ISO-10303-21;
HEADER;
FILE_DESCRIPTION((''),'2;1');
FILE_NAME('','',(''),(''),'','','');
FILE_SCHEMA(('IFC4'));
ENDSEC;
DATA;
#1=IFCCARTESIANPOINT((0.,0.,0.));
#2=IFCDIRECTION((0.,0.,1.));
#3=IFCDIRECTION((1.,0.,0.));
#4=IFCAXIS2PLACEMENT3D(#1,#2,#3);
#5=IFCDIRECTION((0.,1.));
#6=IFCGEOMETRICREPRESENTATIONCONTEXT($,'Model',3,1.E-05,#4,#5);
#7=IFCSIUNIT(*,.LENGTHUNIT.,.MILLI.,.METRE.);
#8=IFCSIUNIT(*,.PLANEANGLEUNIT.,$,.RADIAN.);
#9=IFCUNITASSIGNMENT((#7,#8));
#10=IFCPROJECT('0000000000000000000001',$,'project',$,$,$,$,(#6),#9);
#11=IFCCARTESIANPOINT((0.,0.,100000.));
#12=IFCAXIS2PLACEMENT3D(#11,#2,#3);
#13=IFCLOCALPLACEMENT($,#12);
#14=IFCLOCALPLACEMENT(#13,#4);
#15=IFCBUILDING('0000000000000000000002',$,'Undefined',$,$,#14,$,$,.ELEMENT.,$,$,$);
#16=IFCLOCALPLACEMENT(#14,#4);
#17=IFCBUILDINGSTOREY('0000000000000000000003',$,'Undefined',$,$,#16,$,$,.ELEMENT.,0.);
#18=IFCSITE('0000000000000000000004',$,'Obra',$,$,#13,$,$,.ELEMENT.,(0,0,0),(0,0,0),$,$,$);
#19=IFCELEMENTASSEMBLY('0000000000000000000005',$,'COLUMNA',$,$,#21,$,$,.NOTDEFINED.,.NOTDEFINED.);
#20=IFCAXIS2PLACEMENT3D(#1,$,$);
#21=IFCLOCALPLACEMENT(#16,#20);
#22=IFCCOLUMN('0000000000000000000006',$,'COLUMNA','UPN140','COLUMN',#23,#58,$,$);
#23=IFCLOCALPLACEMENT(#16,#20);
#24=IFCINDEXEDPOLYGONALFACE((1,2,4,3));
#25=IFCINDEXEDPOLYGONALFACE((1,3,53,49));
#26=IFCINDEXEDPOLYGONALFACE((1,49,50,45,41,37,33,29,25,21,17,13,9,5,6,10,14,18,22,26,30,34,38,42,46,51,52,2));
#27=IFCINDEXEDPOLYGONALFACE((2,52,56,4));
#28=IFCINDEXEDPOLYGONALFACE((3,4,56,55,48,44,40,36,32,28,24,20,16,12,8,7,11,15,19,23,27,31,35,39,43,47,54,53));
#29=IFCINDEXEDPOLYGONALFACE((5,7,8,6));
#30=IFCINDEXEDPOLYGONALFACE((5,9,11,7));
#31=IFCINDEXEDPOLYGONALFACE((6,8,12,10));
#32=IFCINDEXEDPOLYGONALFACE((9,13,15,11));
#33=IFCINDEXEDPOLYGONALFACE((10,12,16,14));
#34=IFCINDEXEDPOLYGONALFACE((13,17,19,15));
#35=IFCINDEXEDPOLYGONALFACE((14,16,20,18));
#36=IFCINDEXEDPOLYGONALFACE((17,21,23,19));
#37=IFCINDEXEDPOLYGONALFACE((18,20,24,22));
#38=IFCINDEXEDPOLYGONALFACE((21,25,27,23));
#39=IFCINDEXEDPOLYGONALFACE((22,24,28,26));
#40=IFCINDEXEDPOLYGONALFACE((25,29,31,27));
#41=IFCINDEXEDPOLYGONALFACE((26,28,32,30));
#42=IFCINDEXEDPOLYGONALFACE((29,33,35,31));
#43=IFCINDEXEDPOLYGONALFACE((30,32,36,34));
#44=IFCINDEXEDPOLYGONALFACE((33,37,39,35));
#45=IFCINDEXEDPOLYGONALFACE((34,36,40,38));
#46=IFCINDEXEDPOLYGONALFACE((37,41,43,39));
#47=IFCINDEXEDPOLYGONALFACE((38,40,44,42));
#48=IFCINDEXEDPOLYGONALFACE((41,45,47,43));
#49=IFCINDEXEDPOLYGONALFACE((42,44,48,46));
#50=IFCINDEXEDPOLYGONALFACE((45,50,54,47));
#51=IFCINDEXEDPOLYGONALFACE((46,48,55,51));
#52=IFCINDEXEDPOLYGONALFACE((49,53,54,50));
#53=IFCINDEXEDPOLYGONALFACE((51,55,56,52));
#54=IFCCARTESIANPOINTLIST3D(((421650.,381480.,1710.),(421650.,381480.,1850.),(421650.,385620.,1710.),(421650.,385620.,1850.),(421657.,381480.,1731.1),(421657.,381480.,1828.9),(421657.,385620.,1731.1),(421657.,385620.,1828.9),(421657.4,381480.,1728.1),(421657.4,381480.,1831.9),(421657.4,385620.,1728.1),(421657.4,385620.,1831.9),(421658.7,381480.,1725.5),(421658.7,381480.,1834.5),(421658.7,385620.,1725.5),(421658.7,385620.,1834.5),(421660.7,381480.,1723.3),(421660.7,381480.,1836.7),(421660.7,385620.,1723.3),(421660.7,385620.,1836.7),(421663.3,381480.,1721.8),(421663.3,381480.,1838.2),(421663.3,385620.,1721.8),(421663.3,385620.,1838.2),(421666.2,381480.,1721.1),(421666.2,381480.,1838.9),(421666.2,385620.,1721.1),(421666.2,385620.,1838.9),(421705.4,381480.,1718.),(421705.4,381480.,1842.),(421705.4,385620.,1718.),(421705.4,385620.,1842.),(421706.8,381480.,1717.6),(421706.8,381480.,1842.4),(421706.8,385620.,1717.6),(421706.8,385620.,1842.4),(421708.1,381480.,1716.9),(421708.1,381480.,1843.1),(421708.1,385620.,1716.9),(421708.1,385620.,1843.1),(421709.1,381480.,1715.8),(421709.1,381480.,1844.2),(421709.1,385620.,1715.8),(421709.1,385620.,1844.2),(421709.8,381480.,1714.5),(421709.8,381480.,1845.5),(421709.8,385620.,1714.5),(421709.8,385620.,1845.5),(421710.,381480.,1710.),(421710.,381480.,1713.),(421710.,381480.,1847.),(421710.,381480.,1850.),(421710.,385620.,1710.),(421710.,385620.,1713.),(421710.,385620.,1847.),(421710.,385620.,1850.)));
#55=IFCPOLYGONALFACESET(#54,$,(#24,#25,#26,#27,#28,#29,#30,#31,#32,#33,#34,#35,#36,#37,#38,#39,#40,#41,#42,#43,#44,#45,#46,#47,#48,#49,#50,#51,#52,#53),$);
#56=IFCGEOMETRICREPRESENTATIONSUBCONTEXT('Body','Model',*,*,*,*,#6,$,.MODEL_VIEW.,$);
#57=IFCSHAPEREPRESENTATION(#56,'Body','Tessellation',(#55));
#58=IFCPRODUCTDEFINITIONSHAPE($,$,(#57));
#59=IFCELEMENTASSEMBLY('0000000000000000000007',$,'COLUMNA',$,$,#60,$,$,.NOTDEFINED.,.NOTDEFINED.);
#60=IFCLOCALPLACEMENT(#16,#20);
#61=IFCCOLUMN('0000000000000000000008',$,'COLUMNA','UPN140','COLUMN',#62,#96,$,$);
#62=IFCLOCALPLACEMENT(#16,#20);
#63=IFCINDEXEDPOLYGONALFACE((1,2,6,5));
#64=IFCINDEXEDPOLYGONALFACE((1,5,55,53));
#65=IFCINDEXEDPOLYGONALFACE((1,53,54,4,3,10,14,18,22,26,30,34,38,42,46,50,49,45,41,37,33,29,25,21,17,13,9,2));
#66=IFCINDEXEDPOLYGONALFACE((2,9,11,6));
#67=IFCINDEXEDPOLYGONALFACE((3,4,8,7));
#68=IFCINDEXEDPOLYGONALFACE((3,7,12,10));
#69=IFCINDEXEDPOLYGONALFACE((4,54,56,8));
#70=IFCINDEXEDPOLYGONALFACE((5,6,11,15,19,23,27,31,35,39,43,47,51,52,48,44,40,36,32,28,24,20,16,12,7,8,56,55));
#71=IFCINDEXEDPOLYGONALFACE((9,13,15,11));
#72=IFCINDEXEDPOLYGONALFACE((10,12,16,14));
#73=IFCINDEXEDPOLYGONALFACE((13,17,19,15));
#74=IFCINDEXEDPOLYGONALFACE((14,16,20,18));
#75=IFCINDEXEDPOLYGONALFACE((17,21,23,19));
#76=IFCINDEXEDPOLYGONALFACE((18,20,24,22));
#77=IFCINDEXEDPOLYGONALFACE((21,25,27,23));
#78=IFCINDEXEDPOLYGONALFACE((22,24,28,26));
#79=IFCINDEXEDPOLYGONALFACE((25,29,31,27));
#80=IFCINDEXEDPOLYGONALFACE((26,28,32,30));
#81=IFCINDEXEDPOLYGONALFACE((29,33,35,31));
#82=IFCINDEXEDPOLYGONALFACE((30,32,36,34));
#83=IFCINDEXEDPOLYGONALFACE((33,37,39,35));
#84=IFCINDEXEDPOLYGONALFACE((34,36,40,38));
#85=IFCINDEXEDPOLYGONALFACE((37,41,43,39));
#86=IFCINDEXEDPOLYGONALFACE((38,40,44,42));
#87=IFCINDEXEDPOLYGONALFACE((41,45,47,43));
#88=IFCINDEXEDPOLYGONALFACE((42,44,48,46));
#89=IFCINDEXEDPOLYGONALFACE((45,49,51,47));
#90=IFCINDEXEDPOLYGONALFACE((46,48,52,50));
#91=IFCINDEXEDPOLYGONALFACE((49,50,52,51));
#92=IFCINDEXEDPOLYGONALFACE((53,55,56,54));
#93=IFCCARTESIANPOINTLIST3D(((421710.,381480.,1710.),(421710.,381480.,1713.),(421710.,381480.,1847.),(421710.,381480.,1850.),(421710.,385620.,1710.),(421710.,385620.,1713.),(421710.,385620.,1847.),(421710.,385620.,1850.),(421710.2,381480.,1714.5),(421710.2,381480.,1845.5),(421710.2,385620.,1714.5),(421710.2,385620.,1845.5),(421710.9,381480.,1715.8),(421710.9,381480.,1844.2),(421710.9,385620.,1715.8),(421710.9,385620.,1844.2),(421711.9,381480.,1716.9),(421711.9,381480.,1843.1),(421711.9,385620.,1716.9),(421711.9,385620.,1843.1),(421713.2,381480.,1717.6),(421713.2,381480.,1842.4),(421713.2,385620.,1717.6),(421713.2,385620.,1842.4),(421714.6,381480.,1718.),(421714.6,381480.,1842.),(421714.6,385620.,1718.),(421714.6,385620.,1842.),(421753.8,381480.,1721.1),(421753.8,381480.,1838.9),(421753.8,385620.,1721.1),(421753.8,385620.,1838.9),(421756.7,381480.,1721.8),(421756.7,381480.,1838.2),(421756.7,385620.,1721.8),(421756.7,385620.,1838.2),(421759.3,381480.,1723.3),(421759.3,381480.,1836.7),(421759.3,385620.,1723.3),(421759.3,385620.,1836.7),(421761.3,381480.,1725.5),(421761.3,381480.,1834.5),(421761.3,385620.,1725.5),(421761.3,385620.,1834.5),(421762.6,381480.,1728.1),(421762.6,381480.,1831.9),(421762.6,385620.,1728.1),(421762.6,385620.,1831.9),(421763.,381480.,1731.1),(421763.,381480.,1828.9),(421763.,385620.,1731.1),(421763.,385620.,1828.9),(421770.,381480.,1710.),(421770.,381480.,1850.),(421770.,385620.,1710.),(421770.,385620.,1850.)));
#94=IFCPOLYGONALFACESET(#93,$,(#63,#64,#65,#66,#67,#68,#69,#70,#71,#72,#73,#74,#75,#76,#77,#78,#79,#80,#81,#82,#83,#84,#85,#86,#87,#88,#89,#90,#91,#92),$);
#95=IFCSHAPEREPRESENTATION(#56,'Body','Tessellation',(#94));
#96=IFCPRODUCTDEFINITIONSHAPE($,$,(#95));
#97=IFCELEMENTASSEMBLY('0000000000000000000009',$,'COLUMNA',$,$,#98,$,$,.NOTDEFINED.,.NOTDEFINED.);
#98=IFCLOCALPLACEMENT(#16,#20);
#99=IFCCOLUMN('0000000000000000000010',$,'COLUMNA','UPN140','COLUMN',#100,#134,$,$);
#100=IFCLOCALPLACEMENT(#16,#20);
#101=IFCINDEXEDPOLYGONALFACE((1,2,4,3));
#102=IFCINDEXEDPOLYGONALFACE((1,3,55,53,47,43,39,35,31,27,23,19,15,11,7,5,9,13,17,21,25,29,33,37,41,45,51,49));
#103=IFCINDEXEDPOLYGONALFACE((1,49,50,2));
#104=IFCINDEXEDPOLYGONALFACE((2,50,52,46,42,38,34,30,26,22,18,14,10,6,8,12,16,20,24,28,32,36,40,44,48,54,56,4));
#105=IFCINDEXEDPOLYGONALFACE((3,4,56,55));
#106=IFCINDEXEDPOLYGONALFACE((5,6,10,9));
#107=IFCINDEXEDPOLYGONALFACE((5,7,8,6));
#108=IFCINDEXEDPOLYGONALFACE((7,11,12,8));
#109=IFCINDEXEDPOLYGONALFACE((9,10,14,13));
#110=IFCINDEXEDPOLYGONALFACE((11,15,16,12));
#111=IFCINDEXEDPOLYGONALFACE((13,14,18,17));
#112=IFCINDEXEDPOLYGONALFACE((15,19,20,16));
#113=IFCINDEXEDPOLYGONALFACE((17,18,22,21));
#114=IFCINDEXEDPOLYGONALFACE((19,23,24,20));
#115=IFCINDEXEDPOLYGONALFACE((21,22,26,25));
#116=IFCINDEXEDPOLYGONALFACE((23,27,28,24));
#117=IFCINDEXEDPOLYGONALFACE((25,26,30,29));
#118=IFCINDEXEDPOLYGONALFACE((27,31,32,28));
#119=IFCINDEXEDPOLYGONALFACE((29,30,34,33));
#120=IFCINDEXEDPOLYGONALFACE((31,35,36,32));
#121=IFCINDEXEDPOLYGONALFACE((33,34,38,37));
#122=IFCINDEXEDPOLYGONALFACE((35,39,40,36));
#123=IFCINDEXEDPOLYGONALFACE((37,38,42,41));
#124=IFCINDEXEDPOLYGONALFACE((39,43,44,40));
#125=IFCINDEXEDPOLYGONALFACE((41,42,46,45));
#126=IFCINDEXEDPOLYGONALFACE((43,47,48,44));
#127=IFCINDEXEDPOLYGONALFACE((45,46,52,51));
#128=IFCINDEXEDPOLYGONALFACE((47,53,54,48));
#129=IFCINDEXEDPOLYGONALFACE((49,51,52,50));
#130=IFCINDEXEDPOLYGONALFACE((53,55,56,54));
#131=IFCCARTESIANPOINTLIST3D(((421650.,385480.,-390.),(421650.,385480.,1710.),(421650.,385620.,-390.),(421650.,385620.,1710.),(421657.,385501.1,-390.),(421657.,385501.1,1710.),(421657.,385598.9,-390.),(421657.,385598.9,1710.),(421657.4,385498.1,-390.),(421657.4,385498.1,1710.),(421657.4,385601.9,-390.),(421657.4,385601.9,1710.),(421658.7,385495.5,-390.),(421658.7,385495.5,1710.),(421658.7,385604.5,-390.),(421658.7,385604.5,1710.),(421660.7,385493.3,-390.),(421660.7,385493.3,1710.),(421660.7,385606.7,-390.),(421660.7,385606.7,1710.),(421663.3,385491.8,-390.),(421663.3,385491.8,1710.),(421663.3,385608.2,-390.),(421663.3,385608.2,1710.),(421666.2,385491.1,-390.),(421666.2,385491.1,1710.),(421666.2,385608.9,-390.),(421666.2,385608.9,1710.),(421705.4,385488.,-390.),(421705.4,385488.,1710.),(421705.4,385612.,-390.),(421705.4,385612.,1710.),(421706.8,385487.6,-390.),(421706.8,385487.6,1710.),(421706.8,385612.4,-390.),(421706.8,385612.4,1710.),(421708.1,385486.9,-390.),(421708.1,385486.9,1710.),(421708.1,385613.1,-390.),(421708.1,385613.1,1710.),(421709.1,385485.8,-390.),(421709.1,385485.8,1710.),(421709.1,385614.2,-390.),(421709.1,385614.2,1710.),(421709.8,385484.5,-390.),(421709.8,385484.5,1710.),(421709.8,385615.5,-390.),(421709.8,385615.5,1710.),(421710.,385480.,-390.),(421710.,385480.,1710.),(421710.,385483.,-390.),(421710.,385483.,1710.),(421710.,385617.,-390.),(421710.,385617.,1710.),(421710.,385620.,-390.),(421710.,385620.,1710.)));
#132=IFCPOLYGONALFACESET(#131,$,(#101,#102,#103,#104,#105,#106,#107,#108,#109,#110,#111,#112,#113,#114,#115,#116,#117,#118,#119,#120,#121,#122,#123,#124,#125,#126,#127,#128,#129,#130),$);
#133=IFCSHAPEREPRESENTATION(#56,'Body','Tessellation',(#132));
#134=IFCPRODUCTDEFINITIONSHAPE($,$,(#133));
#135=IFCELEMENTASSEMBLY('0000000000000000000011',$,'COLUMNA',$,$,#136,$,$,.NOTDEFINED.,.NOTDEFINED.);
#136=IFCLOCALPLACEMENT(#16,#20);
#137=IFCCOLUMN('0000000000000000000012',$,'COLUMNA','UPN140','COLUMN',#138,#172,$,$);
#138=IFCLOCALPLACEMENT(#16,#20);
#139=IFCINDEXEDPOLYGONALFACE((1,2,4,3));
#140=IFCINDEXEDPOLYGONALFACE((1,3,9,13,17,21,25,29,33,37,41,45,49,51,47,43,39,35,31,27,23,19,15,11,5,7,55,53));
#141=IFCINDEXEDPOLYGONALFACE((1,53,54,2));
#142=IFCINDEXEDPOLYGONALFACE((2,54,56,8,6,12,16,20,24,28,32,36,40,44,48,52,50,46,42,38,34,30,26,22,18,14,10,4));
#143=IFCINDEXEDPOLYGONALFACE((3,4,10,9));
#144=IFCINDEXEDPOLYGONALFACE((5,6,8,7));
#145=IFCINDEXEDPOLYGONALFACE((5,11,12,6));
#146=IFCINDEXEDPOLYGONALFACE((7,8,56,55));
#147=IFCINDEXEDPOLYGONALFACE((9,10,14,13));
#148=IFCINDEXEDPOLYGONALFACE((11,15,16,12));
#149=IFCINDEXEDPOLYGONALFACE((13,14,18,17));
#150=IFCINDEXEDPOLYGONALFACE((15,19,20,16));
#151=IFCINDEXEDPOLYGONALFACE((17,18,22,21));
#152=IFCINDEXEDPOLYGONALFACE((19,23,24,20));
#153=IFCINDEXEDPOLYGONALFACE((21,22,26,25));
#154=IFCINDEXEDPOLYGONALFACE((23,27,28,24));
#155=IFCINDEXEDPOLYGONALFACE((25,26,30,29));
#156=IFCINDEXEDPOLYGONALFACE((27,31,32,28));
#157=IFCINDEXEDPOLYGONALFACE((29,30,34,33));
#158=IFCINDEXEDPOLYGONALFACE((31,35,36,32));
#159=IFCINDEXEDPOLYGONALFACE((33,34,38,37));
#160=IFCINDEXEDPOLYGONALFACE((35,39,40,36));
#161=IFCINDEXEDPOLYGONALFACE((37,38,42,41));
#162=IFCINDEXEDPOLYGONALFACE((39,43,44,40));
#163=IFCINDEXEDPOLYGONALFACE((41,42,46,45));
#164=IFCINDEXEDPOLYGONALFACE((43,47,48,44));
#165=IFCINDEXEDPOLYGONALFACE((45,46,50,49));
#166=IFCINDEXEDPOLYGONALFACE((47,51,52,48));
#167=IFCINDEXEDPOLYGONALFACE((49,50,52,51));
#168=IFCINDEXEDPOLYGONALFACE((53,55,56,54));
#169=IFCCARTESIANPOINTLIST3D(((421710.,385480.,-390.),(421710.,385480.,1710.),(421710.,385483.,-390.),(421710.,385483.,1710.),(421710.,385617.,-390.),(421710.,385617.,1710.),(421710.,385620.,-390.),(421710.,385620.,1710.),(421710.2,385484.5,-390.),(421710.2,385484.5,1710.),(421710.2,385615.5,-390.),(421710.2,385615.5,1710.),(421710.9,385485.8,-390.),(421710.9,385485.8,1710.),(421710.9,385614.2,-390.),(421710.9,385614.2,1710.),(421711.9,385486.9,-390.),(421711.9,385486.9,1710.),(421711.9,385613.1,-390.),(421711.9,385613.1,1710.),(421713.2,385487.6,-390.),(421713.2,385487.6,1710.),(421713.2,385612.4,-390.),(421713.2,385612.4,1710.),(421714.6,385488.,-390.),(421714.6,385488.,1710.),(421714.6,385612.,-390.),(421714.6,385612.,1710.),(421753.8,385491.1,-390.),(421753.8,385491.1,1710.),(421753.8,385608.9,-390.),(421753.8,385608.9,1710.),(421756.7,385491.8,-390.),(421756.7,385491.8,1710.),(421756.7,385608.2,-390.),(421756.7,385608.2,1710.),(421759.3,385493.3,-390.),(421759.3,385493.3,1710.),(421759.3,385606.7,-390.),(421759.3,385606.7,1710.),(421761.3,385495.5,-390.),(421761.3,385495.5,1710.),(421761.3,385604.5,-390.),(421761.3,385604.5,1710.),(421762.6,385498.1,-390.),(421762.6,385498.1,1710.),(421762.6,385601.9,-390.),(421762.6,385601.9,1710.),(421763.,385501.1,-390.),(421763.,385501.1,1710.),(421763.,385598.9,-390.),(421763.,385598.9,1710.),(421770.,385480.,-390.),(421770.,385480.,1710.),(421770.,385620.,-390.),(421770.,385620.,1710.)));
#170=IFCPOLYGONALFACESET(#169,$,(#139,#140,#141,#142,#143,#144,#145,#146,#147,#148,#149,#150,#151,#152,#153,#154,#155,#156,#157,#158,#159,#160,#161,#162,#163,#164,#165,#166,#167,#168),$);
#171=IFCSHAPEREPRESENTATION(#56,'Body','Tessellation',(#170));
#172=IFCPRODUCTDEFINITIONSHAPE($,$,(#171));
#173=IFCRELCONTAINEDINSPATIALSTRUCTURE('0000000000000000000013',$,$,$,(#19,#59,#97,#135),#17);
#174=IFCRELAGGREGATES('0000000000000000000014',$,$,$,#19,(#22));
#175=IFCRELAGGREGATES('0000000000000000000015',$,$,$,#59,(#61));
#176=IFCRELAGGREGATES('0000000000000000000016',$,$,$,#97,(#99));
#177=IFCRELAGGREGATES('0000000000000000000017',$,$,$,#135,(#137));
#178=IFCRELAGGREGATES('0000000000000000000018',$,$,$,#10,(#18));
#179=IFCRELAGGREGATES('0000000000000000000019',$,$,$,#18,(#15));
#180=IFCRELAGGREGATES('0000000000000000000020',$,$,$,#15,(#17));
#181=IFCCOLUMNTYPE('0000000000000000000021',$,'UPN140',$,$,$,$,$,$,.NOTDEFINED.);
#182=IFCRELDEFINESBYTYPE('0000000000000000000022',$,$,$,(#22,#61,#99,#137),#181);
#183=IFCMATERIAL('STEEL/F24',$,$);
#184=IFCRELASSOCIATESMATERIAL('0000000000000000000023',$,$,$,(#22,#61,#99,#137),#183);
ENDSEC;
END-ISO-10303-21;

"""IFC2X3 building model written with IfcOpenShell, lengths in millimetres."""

from ifc_helpers import new_model, si_unit, direction, frame, origin_with_axes, origin_2d_with_axis, place, context, subcontext, project, spatial, u_section, extrude, material, type_object, element, aggregate, save


model = new_model("IFC2X3")

# Units and contexts
model_context = context("Model", 3, precision=1e-05, world=origin_with_axes(), true_north=direction((0.0, 1.0)))
body_context = subcontext(model_context, "Body", "Model", "MODEL_VIEW")
ifc_project = project(units=[si_unit("LENGTHUNIT", "METRE", prefix="MILLI"), si_unit("PLANEANGLEUNIT", "RADIAN")], contexts=[model_context])

# Site, building, storey
site_placement = place(None, frame((0.0, 0.0, 100000.0), z_axis=(0.0, 0.0, 1.0), x_axis=(1.0, 0.0, 0.0)))
site = spatial("IfcSite", under=ifc_project, at=site_placement, Name="Obra", CompositionType="ELEMENT", RefLatitude=(0, 0, 0), RefLongitude=(0, 0, 0))
building_placement = place(site_placement, origin_with_axes())
building = spatial("IfcBuilding", under=site, at=building_placement, Name="Undefined", CompositionType="ELEMENT")
storey_placement = place(building_placement, origin_with_axes())
storey = spatial("IfcBuildingStorey", under=building, at=storey_placement, Name="Undefined", CompositionType="ELEMENT", Elevation=0.0)

# Element assemblies, columns
ifc_material_1 = material(Name="STEEL/F24")
column_type_1 = type_object("IfcColumnType", Name="UPN140", PredefinedType="NOTDEFINED")
assembly_1_placement = place(storey_placement, origin_with_axes())
assembly_1 = element("IfcElementAssembly", 1, at=assembly_1_placement, inside=storey, Name="COLUMNA", AssemblyPlace="NOTDEFINED", PredefinedType="NOTDEFINED")
column_1_placement = place(assembly_1_placement, frame((421680.0, 385620.0, 1780.0), z_axis=(0.0, -1.0, 0.0), x_axis=(0.0, 0.0, -1.0)))
column_1 = element("IfcColumn", 2, at=column_1_placement, type_object=column_type_1, material=ifc_material_1, Name="COLUMNA", Description="UPN140", ObjectType="COLUMN", context=body_context, shape_type="SweptSolid", body=[
    extrude(u_section(Depth=140.0, FlangeWidth=60.0, WebThickness=7.0, FlangeThickness=10.0, FilletRadius=10.0, EdgeRadius=5.0, FlangeSlope=0.07983, at=origin_2d_with_axis()), frame((0.0, 0.0, 4140.0), z_axis=(0.0, 0.0, -1.0), x_axis=(0.0, 1.0, 0.0)), (0.0, 0.0, 1.0), 4140.0),
])
aggregate(assembly_1, [column_1])
assembly_2_placement = place(storey_placement, origin_with_axes())
assembly_2 = element("IfcElementAssembly", 3, at=assembly_2_placement, inside=storey, Name="COLUMNA", AssemblyPlace="NOTDEFINED", PredefinedType="NOTDEFINED")
column_2_placement = place(assembly_2_placement, frame((421740.0, 385620.0, 1780.0), z_axis=(0.0, -1.0, 0.0), x_axis=(0.0, 0.0, 1.0)))
column_2 = element("IfcColumn", 4, at=column_2_placement, type_object=column_type_1, material=ifc_material_1, Name="COLUMNA", Description="UPN140", ObjectType="COLUMN", context=body_context, shape_type="SweptSolid", body=[
    extrude(u_section(Depth=140.0, FlangeWidth=60.0, WebThickness=7.0, FlangeThickness=10.0, FilletRadius=10.0, EdgeRadius=5.0, FlangeSlope=0.07983, at=origin_2d_with_axis()), frame((0.0, 0.0, 4140.0), z_axis=(0.0, 0.0, -1.0), x_axis=(0.0, 1.0, 0.0)), (0.0, 0.0, 1.0), 4140.0),
])
aggregate(assembly_2, [column_2])
assembly_3_placement = place(storey_placement, origin_with_axes())
assembly_3 = element("IfcElementAssembly", 5, at=assembly_3_placement, inside=storey, Name="COLUMNA", AssemblyPlace="NOTDEFINED", PredefinedType="NOTDEFINED")
column_3_placement = place(assembly_3_placement, frame((421680.0, 385550.0, -390.0), z_axis=(0.0, 0.0, 1.0), x_axis=(0.0, -1.0, 0.0)))
column_3 = element("IfcColumn", 6, at=column_3_placement, type_object=column_type_1, material=ifc_material_1, Name="COLUMNA", Description="UPN140", ObjectType="COLUMN", context=body_context, shape_type="SweptSolid", body=[
    extrude(u_section(Depth=140.0, FlangeWidth=60.0, WebThickness=7.0, FlangeThickness=10.0, FilletRadius=10.0, EdgeRadius=5.0, FlangeSlope=0.07983, at=origin_2d_with_axis()), frame((0.0, 0.0, 2100.0), z_axis=(0.0, 0.0, -1.0), x_axis=(0.0, 1.0, 0.0)), (0.0, 0.0, 1.0), 2100.0),
])
aggregate(assembly_3, [column_3])
assembly_4_placement = place(storey_placement, origin_with_axes())
assembly_4 = element("IfcElementAssembly", 7, at=assembly_4_placement, inside=storey, Name="COLUMNA", AssemblyPlace="NOTDEFINED", PredefinedType="NOTDEFINED")
column_4_placement = place(assembly_4_placement, frame((421740.0, 385550.0, -390.0), z_axis=(0.0, 0.0, 1.0), x_axis=(0.0, 1.0, 0.0)))
column_4 = element("IfcColumn", 8, at=column_4_placement, type_object=column_type_1, material=ifc_material_1, Name="COLUMNA", Description="UPN140", ObjectType="COLUMN", context=body_context, shape_type="SweptSolid", body=[
    extrude(u_section(Depth=140.0, FlangeWidth=60.0, WebThickness=7.0, FlangeThickness=10.0, FilletRadius=10.0, EdgeRadius=5.0, FlangeSlope=0.07983, at=origin_2d_with_axis()), frame((0.0, 0.0, 2100.0), z_axis=(0.0, 0.0, -1.0), x_axis=(0.0, 1.0, 0.0)), (0.0, 0.0, 1.0), 2100.0),
])
aggregate(assembly_4, [column_4])

save(model, "model.ifc")
